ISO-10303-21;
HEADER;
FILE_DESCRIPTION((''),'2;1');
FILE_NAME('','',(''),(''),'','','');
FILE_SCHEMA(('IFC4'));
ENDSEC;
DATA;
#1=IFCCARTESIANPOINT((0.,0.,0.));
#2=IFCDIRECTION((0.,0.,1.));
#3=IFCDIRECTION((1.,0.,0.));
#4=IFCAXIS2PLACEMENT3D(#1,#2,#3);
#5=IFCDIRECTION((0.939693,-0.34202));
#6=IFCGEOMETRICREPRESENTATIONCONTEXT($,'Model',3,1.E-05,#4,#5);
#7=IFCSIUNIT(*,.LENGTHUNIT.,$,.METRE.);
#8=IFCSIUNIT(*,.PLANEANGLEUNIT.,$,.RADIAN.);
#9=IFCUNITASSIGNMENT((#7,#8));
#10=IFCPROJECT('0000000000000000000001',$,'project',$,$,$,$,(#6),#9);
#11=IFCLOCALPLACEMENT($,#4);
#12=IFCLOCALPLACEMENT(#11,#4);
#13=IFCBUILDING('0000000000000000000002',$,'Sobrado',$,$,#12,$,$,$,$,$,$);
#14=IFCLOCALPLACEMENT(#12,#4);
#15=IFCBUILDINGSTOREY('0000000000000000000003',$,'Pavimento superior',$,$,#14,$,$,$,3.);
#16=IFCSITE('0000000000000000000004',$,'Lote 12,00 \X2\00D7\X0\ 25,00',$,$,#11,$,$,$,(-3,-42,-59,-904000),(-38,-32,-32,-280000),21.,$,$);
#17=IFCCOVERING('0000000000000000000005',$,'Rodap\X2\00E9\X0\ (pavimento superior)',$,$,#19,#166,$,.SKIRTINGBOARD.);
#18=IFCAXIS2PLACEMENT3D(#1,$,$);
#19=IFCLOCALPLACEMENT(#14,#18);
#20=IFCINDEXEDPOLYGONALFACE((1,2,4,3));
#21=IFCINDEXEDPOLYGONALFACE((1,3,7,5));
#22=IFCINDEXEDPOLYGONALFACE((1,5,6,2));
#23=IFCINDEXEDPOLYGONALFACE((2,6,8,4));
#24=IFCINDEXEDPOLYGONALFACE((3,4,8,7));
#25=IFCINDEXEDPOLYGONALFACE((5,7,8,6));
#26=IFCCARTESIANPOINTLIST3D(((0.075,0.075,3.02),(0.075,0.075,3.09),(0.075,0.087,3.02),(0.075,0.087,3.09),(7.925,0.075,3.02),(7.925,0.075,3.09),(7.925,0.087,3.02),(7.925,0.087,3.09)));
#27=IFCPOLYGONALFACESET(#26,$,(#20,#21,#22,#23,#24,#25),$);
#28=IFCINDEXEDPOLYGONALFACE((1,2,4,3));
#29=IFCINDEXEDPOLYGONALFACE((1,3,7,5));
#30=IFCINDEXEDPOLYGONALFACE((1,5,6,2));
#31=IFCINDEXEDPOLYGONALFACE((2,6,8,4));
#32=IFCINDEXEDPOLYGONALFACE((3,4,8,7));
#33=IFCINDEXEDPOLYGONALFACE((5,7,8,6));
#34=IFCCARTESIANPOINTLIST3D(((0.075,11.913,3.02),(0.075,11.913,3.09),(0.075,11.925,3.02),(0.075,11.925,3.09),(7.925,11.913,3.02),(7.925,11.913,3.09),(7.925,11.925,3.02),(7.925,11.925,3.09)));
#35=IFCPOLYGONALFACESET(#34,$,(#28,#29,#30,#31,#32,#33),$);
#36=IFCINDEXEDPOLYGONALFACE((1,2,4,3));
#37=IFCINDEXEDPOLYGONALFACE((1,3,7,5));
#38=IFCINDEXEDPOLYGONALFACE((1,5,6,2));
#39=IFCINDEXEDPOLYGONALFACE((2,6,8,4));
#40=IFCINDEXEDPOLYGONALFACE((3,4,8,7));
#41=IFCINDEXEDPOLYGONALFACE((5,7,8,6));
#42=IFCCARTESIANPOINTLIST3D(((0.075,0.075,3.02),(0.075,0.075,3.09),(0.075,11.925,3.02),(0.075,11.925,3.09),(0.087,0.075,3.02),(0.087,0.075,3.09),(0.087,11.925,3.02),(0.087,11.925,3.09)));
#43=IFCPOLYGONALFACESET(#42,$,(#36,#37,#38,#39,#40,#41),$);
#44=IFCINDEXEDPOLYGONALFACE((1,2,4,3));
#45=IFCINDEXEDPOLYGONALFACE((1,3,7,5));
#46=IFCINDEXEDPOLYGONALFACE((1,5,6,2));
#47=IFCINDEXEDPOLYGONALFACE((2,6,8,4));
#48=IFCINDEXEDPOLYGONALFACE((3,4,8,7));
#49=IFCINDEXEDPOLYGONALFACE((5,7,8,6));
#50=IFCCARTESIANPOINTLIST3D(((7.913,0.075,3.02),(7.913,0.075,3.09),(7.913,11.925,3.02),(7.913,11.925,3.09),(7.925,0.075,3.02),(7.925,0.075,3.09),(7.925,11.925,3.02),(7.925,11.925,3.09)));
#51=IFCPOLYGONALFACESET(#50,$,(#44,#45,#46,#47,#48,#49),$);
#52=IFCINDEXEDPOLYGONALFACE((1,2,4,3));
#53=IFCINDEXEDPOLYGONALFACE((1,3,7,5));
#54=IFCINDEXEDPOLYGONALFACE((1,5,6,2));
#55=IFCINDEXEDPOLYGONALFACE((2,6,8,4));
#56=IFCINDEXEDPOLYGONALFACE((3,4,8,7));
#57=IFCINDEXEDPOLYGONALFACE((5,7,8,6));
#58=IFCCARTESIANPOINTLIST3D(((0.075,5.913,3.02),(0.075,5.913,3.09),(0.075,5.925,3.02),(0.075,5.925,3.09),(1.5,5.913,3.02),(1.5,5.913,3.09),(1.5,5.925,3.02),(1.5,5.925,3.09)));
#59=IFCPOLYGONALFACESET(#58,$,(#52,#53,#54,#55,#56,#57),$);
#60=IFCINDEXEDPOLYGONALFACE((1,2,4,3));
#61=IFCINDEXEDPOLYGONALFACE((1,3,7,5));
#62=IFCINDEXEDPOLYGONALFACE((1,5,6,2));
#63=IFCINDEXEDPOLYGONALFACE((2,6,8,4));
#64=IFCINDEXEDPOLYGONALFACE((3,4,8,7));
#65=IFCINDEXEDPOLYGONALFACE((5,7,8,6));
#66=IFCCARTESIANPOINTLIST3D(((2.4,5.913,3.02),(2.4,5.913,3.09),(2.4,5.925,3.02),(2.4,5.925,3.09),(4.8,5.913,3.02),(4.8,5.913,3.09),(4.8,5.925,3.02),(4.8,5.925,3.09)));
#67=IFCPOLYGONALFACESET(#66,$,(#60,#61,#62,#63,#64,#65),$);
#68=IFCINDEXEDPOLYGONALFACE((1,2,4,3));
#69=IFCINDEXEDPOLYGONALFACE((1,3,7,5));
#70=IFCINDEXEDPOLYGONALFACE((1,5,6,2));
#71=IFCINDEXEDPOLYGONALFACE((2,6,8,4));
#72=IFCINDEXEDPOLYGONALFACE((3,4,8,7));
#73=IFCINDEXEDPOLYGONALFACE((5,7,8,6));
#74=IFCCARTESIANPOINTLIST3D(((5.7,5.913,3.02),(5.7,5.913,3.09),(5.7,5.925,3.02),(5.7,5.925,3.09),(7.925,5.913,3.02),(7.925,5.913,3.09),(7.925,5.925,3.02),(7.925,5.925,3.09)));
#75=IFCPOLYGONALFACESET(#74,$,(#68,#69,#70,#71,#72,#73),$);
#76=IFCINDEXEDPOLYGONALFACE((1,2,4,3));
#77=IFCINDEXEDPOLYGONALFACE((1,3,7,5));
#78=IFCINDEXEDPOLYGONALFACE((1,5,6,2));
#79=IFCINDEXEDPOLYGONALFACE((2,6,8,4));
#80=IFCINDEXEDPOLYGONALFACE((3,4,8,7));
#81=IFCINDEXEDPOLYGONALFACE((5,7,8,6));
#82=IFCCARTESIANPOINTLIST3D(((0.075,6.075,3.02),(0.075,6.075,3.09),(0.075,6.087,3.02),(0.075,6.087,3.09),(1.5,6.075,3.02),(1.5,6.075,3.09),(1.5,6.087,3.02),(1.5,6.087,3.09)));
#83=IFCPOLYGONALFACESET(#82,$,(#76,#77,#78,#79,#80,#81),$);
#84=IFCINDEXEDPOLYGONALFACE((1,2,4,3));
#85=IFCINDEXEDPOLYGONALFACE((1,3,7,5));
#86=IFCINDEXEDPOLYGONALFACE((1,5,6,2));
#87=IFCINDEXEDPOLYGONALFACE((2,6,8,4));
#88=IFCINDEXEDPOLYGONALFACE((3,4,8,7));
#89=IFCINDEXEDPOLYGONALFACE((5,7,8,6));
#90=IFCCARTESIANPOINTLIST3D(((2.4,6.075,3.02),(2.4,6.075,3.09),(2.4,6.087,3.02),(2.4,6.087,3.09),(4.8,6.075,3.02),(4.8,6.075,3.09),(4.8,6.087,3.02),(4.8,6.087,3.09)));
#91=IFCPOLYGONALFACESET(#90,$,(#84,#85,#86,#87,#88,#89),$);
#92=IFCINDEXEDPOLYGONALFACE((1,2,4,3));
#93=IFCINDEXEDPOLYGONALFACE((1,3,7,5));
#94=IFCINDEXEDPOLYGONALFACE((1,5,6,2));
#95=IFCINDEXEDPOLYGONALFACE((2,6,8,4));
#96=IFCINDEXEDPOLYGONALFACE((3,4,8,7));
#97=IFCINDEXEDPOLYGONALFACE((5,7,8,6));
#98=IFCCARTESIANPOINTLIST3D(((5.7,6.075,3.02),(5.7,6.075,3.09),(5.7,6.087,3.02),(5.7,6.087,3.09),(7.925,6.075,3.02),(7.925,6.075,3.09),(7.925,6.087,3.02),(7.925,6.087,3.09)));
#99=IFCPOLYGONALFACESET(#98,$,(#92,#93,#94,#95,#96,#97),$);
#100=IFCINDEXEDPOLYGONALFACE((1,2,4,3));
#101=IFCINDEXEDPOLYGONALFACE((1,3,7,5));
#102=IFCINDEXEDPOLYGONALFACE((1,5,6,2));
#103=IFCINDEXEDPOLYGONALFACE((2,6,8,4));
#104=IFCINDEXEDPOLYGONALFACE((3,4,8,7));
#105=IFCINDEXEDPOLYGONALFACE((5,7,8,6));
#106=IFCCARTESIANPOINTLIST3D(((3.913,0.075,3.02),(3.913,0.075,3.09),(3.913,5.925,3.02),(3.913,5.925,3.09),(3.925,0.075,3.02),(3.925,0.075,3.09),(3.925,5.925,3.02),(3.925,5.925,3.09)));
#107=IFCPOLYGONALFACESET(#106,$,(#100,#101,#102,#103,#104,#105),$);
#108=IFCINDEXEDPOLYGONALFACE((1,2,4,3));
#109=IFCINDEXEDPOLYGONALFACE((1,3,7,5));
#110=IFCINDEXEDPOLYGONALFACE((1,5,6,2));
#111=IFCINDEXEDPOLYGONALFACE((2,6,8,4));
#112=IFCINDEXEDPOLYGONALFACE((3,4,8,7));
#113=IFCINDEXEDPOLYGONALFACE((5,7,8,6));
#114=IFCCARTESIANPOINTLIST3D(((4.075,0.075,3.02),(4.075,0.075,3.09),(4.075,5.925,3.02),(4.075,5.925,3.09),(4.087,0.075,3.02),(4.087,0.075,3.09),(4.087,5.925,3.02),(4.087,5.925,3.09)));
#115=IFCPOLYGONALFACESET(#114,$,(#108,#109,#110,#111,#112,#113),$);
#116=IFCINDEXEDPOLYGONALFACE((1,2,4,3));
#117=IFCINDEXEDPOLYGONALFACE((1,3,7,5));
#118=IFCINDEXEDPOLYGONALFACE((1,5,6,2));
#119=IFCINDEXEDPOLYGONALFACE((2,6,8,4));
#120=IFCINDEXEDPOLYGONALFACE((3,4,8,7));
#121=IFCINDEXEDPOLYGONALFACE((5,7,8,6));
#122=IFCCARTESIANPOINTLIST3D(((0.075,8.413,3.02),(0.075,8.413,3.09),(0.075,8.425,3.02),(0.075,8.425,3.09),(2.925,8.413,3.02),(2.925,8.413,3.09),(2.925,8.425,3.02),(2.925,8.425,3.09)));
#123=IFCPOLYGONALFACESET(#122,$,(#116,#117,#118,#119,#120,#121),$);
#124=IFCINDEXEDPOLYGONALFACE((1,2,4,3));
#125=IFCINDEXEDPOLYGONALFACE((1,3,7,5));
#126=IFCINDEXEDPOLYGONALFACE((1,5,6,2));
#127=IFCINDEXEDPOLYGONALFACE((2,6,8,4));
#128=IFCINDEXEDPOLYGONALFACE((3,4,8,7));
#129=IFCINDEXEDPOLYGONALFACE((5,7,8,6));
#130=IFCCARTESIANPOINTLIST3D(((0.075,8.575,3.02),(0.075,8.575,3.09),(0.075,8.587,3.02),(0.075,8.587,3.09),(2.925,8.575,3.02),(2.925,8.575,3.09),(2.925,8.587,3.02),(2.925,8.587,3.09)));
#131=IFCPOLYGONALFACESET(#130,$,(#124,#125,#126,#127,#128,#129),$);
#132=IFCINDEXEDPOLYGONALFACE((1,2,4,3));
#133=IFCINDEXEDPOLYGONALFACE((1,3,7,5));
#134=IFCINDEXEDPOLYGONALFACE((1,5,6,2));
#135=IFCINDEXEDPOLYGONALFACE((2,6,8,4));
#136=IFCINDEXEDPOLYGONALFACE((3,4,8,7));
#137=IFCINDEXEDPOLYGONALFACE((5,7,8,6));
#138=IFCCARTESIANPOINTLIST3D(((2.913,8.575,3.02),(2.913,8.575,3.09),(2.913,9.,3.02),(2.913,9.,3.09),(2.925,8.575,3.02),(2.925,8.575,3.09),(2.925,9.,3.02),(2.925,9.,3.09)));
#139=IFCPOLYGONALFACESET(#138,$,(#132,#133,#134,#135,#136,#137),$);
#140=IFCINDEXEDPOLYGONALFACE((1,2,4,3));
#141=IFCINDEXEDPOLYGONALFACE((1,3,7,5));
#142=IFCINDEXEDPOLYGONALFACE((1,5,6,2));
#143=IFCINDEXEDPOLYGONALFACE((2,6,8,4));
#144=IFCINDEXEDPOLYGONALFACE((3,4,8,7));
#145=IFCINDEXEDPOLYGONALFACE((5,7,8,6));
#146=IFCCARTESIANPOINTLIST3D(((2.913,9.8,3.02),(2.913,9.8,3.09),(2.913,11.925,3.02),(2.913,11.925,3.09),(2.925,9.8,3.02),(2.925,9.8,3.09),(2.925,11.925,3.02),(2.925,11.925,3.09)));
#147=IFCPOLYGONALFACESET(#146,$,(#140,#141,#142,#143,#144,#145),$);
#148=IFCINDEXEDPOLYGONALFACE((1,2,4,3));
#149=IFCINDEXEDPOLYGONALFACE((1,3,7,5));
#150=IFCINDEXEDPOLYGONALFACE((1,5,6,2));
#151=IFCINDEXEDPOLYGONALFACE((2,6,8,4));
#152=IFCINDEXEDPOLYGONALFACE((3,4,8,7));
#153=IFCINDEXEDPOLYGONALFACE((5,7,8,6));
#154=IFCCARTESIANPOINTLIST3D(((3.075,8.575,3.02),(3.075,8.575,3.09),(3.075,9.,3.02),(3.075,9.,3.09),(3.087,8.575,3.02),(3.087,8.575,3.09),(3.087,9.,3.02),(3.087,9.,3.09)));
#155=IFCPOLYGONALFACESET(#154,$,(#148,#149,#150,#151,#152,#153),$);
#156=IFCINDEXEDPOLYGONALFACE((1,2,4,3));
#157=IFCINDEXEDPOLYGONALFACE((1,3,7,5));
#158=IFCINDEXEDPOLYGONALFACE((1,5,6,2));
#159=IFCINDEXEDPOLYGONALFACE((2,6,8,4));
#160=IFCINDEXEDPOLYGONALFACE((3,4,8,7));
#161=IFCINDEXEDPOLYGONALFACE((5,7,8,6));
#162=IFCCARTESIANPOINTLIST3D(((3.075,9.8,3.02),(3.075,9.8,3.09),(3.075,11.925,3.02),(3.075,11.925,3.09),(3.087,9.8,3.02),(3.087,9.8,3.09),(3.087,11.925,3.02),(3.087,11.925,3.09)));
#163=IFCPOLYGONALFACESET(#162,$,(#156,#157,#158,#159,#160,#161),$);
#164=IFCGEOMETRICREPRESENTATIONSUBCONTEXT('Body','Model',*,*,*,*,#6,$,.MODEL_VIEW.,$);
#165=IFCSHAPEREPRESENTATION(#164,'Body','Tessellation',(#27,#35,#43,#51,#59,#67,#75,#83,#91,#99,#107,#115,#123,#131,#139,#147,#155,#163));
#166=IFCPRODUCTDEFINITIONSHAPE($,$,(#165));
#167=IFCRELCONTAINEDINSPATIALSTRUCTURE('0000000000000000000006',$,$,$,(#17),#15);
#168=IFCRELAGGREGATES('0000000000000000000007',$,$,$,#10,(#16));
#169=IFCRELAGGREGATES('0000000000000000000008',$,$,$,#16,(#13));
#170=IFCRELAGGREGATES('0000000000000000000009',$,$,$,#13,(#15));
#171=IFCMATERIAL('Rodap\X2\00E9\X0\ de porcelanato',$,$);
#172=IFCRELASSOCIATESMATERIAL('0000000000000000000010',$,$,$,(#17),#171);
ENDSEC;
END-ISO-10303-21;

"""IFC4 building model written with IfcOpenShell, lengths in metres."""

from ifc_helpers import new_model, si_unit, direction, frame, origin_with_axes, place, context, subcontext, project, spatial, line, indexed_curve, outline, extrude, material, element, save


model = new_model("IFC4")

# Units and contexts
model_context = context("Model", 3, precision=1e-05, world=origin_with_axes(), true_north=direction((0.939693, -0.34202)))
body_context = subcontext(model_context, "Body", "Model", "MODEL_VIEW")
ifc_project = project(units=[si_unit("LENGTHUNIT", "METRE"), si_unit("PLANEANGLEUNIT", "RADIAN")], contexts=[model_context])

# Site, building, storey
site_placement = place(None, origin_with_axes())
site = spatial("IfcSite", under=ifc_project, at=site_placement, Name="Lote 12,00 × 25,00", RefLatitude=(-3, -42, -59, -904000), RefLongitude=(-38, -32, -32, -280000), RefElevation=21.0)
building_placement = place(site_placement, origin_with_axes())
building = spatial("IfcBuilding", under=site, at=building_placement, Name="Sobrado")
storey_placement = place(building_placement, origin_with_axes())
storey = spatial("IfcBuildingStorey", under=building, at=storey_placement, Name="Pavimento superior", Elevation=3.0)

# Covering
ifc_material_1 = material(Name="Rodapé de porcelanato")
covering_1_placement = place(storey_placement, origin_with_axes())
element("IfcCovering", 1, at=covering_1_placement, inside=storey, material=ifc_material_1, Name="Rodapé (pavimento superior)", PredefinedType="SKIRTINGBOARD", context=body_context, shape_type="SweptSolid", body=[
    extrude(outline(indexed_curve([(0.075, 0.075), (7.925, 0.075), (7.925, 0.087), (0.075, 0.087)], segments=[line(1, 2, 3, 4, 1)])), frame((0.0, 0.0, 3.02), z_axis=(0.0, 0.0, 1.0), x_axis=(1.0, 0.0, 0.0)), (0.0, 0.0, 1.0), 0.07),
    extrude(outline(indexed_curve([(0.075, 11.913), (7.925, 11.913), (7.925, 11.925), (0.075, 11.925)], segments=[line(1, 2, 3, 4, 1)])), frame((0.0, 0.0, 3.02), z_axis=(0.0, 0.0, 1.0), x_axis=(1.0, 0.0, 0.0)), (0.0, 0.0, 1.0), 0.07),
    extrude(outline(indexed_curve([(0.075, 0.075), (0.087, 0.075), (0.087, 11.925), (0.075, 11.925)], segments=[line(1, 2, 3, 4, 1)])), frame((0.0, 0.0, 3.02), z_axis=(0.0, 0.0, 1.0), x_axis=(1.0, 0.0, 0.0)), (0.0, 0.0, 1.0), 0.07),
    extrude(outline(indexed_curve([(7.913, 0.075), (7.925, 0.075), (7.925, 11.925), (7.913, 11.925)], segments=[line(1, 2, 3, 4, 1)])), frame((0.0, 0.0, 3.02), z_axis=(0.0, 0.0, 1.0), x_axis=(1.0, 0.0, 0.0)), (0.0, 0.0, 1.0), 0.07),
    extrude(outline(indexed_curve([(0.075, 5.913), (1.5, 5.913), (1.5, 5.925), (0.075, 5.925)], segments=[line(1, 2, 3, 4, 1)])), frame((0.0, 0.0, 3.02), z_axis=(0.0, 0.0, 1.0), x_axis=(1.0, 0.0, 0.0)), (0.0, 0.0, 1.0), 0.07),
    extrude(outline(indexed_curve([(2.4, 5.913), (4.8, 5.913), (4.8, 5.925), (2.4, 5.925)], segments=[line(1, 2, 3, 4, 1)])), frame((0.0, 0.0, 3.02), z_axis=(0.0, 0.0, 1.0), x_axis=(1.0, 0.0, 0.0)), (0.0, 0.0, 1.0), 0.07),
    extrude(outline(indexed_curve([(5.7, 5.913), (7.925, 5.913), (7.925, 5.925), (5.7, 5.925)], segments=[line(1, 2, 3, 4, 1)])), frame((0.0, 0.0, 3.02), z_axis=(0.0, 0.0, 1.0), x_axis=(1.0, 0.0, 0.0)), (0.0, 0.0, 1.0), 0.07),
    extrude(outline(indexed_curve([(0.075, 6.075), (1.5, 6.075), (1.5, 6.087), (0.075, 6.087)], segments=[line(1, 2, 3, 4, 1)])), frame((0.0, 0.0, 3.02), z_axis=(0.0, 0.0, 1.0), x_axis=(1.0, 0.0, 0.0)), (0.0, 0.0, 1.0), 0.07),
    extrude(outline(indexed_curve([(2.4, 6.075), (4.8, 6.075), (4.8, 6.087), (2.4, 6.087)], segments=[line(1, 2, 3, 4, 1)])), frame((0.0, 0.0, 3.02), z_axis=(0.0, 0.0, 1.0), x_axis=(1.0, 0.0, 0.0)), (0.0, 0.0, 1.0), 0.07),
    extrude(outline(indexed_curve([(5.7, 6.075), (7.925, 6.075), (7.925, 6.087), (5.7, 6.087)], segments=[line(1, 2, 3, 4, 1)])), frame((0.0, 0.0, 3.02), z_axis=(0.0, 0.0, 1.0), x_axis=(1.0, 0.0, 0.0)), (0.0, 0.0, 1.0), 0.07),
    extrude(outline(indexed_curve([(3.913, 0.075), (3.925, 0.075), (3.925, 5.925), (3.913, 5.925)], segments=[line(1, 2, 3, 4, 1)])), frame((0.0, 0.0, 3.02), z_axis=(0.0, 0.0, 1.0), x_axis=(1.0, 0.0, 0.0)), (0.0, 0.0, 1.0), 0.07),
    extrude(outline(indexed_curve([(4.075, 0.075), (4.087, 0.075), (4.087, 5.925), (4.075, 5.925)], segments=[line(1, 2, 3, 4, 1)])), frame((0.0, 0.0, 3.02), z_axis=(0.0, 0.0, 1.0), x_axis=(1.0, 0.0, 0.0)), (0.0, 0.0, 1.0), 0.07),
    extrude(outline(indexed_curve([(0.075, 8.413), (2.925, 8.413), (2.925, 8.425), (0.075, 8.425)], segments=[line(1, 2, 3, 4, 1)])), frame((0.0, 0.0, 3.02), z_axis=(0.0, 0.0, 1.0), x_axis=(1.0, 0.0, 0.0)), (0.0, 0.0, 1.0), 0.07),
    extrude(outline(indexed_curve([(0.075, 8.575), (2.925, 8.575), (2.925, 8.587), (0.075, 8.587)], segments=[line(1, 2, 3, 4, 1)])), frame((0.0, 0.0, 3.02), z_axis=(0.0, 0.0, 1.0), x_axis=(1.0, 0.0, 0.0)), (0.0, 0.0, 1.0), 0.07),
    extrude(outline(indexed_curve([(2.913, 8.575), (2.925, 8.575), (2.925, 9.0), (2.913, 9.0)], segments=[line(1, 2, 3, 4, 1)])), frame((0.0, 0.0, 3.02), z_axis=(0.0, 0.0, 1.0), x_axis=(1.0, 0.0, 0.0)), (0.0, 0.0, 1.0), 0.07),
    extrude(outline(indexed_curve([(2.913, 9.8), (2.925, 9.8), (2.925, 11.925), (2.913, 11.925)], segments=[line(1, 2, 3, 4, 1)])), frame((0.0, 0.0, 3.02), z_axis=(0.0, 0.0, 1.0), x_axis=(1.0, 0.0, 0.0)), (0.0, 0.0, 1.0), 0.07),
    extrude(outline(indexed_curve([(3.075, 8.575), (3.087, 8.575), (3.087, 9.0), (3.075, 9.0)], segments=[line(1, 2, 3, 4, 1)])), frame((0.0, 0.0, 3.02), z_axis=(0.0, 0.0, 1.0), x_axis=(1.0, 0.0, 0.0)), (0.0, 0.0, 1.0), 0.07),
    extrude(outline(indexed_curve([(3.075, 9.8), (3.087, 9.8), (3.087, 11.925), (3.075, 11.925)], segments=[line(1, 2, 3, 4, 1)])), frame((0.0, 0.0, 3.02), z_axis=(0.0, 0.0, 1.0), x_axis=(1.0, 0.0, 0.0)), (0.0, 0.0, 1.0), 0.07),
])

save(model, "model.ifc")
